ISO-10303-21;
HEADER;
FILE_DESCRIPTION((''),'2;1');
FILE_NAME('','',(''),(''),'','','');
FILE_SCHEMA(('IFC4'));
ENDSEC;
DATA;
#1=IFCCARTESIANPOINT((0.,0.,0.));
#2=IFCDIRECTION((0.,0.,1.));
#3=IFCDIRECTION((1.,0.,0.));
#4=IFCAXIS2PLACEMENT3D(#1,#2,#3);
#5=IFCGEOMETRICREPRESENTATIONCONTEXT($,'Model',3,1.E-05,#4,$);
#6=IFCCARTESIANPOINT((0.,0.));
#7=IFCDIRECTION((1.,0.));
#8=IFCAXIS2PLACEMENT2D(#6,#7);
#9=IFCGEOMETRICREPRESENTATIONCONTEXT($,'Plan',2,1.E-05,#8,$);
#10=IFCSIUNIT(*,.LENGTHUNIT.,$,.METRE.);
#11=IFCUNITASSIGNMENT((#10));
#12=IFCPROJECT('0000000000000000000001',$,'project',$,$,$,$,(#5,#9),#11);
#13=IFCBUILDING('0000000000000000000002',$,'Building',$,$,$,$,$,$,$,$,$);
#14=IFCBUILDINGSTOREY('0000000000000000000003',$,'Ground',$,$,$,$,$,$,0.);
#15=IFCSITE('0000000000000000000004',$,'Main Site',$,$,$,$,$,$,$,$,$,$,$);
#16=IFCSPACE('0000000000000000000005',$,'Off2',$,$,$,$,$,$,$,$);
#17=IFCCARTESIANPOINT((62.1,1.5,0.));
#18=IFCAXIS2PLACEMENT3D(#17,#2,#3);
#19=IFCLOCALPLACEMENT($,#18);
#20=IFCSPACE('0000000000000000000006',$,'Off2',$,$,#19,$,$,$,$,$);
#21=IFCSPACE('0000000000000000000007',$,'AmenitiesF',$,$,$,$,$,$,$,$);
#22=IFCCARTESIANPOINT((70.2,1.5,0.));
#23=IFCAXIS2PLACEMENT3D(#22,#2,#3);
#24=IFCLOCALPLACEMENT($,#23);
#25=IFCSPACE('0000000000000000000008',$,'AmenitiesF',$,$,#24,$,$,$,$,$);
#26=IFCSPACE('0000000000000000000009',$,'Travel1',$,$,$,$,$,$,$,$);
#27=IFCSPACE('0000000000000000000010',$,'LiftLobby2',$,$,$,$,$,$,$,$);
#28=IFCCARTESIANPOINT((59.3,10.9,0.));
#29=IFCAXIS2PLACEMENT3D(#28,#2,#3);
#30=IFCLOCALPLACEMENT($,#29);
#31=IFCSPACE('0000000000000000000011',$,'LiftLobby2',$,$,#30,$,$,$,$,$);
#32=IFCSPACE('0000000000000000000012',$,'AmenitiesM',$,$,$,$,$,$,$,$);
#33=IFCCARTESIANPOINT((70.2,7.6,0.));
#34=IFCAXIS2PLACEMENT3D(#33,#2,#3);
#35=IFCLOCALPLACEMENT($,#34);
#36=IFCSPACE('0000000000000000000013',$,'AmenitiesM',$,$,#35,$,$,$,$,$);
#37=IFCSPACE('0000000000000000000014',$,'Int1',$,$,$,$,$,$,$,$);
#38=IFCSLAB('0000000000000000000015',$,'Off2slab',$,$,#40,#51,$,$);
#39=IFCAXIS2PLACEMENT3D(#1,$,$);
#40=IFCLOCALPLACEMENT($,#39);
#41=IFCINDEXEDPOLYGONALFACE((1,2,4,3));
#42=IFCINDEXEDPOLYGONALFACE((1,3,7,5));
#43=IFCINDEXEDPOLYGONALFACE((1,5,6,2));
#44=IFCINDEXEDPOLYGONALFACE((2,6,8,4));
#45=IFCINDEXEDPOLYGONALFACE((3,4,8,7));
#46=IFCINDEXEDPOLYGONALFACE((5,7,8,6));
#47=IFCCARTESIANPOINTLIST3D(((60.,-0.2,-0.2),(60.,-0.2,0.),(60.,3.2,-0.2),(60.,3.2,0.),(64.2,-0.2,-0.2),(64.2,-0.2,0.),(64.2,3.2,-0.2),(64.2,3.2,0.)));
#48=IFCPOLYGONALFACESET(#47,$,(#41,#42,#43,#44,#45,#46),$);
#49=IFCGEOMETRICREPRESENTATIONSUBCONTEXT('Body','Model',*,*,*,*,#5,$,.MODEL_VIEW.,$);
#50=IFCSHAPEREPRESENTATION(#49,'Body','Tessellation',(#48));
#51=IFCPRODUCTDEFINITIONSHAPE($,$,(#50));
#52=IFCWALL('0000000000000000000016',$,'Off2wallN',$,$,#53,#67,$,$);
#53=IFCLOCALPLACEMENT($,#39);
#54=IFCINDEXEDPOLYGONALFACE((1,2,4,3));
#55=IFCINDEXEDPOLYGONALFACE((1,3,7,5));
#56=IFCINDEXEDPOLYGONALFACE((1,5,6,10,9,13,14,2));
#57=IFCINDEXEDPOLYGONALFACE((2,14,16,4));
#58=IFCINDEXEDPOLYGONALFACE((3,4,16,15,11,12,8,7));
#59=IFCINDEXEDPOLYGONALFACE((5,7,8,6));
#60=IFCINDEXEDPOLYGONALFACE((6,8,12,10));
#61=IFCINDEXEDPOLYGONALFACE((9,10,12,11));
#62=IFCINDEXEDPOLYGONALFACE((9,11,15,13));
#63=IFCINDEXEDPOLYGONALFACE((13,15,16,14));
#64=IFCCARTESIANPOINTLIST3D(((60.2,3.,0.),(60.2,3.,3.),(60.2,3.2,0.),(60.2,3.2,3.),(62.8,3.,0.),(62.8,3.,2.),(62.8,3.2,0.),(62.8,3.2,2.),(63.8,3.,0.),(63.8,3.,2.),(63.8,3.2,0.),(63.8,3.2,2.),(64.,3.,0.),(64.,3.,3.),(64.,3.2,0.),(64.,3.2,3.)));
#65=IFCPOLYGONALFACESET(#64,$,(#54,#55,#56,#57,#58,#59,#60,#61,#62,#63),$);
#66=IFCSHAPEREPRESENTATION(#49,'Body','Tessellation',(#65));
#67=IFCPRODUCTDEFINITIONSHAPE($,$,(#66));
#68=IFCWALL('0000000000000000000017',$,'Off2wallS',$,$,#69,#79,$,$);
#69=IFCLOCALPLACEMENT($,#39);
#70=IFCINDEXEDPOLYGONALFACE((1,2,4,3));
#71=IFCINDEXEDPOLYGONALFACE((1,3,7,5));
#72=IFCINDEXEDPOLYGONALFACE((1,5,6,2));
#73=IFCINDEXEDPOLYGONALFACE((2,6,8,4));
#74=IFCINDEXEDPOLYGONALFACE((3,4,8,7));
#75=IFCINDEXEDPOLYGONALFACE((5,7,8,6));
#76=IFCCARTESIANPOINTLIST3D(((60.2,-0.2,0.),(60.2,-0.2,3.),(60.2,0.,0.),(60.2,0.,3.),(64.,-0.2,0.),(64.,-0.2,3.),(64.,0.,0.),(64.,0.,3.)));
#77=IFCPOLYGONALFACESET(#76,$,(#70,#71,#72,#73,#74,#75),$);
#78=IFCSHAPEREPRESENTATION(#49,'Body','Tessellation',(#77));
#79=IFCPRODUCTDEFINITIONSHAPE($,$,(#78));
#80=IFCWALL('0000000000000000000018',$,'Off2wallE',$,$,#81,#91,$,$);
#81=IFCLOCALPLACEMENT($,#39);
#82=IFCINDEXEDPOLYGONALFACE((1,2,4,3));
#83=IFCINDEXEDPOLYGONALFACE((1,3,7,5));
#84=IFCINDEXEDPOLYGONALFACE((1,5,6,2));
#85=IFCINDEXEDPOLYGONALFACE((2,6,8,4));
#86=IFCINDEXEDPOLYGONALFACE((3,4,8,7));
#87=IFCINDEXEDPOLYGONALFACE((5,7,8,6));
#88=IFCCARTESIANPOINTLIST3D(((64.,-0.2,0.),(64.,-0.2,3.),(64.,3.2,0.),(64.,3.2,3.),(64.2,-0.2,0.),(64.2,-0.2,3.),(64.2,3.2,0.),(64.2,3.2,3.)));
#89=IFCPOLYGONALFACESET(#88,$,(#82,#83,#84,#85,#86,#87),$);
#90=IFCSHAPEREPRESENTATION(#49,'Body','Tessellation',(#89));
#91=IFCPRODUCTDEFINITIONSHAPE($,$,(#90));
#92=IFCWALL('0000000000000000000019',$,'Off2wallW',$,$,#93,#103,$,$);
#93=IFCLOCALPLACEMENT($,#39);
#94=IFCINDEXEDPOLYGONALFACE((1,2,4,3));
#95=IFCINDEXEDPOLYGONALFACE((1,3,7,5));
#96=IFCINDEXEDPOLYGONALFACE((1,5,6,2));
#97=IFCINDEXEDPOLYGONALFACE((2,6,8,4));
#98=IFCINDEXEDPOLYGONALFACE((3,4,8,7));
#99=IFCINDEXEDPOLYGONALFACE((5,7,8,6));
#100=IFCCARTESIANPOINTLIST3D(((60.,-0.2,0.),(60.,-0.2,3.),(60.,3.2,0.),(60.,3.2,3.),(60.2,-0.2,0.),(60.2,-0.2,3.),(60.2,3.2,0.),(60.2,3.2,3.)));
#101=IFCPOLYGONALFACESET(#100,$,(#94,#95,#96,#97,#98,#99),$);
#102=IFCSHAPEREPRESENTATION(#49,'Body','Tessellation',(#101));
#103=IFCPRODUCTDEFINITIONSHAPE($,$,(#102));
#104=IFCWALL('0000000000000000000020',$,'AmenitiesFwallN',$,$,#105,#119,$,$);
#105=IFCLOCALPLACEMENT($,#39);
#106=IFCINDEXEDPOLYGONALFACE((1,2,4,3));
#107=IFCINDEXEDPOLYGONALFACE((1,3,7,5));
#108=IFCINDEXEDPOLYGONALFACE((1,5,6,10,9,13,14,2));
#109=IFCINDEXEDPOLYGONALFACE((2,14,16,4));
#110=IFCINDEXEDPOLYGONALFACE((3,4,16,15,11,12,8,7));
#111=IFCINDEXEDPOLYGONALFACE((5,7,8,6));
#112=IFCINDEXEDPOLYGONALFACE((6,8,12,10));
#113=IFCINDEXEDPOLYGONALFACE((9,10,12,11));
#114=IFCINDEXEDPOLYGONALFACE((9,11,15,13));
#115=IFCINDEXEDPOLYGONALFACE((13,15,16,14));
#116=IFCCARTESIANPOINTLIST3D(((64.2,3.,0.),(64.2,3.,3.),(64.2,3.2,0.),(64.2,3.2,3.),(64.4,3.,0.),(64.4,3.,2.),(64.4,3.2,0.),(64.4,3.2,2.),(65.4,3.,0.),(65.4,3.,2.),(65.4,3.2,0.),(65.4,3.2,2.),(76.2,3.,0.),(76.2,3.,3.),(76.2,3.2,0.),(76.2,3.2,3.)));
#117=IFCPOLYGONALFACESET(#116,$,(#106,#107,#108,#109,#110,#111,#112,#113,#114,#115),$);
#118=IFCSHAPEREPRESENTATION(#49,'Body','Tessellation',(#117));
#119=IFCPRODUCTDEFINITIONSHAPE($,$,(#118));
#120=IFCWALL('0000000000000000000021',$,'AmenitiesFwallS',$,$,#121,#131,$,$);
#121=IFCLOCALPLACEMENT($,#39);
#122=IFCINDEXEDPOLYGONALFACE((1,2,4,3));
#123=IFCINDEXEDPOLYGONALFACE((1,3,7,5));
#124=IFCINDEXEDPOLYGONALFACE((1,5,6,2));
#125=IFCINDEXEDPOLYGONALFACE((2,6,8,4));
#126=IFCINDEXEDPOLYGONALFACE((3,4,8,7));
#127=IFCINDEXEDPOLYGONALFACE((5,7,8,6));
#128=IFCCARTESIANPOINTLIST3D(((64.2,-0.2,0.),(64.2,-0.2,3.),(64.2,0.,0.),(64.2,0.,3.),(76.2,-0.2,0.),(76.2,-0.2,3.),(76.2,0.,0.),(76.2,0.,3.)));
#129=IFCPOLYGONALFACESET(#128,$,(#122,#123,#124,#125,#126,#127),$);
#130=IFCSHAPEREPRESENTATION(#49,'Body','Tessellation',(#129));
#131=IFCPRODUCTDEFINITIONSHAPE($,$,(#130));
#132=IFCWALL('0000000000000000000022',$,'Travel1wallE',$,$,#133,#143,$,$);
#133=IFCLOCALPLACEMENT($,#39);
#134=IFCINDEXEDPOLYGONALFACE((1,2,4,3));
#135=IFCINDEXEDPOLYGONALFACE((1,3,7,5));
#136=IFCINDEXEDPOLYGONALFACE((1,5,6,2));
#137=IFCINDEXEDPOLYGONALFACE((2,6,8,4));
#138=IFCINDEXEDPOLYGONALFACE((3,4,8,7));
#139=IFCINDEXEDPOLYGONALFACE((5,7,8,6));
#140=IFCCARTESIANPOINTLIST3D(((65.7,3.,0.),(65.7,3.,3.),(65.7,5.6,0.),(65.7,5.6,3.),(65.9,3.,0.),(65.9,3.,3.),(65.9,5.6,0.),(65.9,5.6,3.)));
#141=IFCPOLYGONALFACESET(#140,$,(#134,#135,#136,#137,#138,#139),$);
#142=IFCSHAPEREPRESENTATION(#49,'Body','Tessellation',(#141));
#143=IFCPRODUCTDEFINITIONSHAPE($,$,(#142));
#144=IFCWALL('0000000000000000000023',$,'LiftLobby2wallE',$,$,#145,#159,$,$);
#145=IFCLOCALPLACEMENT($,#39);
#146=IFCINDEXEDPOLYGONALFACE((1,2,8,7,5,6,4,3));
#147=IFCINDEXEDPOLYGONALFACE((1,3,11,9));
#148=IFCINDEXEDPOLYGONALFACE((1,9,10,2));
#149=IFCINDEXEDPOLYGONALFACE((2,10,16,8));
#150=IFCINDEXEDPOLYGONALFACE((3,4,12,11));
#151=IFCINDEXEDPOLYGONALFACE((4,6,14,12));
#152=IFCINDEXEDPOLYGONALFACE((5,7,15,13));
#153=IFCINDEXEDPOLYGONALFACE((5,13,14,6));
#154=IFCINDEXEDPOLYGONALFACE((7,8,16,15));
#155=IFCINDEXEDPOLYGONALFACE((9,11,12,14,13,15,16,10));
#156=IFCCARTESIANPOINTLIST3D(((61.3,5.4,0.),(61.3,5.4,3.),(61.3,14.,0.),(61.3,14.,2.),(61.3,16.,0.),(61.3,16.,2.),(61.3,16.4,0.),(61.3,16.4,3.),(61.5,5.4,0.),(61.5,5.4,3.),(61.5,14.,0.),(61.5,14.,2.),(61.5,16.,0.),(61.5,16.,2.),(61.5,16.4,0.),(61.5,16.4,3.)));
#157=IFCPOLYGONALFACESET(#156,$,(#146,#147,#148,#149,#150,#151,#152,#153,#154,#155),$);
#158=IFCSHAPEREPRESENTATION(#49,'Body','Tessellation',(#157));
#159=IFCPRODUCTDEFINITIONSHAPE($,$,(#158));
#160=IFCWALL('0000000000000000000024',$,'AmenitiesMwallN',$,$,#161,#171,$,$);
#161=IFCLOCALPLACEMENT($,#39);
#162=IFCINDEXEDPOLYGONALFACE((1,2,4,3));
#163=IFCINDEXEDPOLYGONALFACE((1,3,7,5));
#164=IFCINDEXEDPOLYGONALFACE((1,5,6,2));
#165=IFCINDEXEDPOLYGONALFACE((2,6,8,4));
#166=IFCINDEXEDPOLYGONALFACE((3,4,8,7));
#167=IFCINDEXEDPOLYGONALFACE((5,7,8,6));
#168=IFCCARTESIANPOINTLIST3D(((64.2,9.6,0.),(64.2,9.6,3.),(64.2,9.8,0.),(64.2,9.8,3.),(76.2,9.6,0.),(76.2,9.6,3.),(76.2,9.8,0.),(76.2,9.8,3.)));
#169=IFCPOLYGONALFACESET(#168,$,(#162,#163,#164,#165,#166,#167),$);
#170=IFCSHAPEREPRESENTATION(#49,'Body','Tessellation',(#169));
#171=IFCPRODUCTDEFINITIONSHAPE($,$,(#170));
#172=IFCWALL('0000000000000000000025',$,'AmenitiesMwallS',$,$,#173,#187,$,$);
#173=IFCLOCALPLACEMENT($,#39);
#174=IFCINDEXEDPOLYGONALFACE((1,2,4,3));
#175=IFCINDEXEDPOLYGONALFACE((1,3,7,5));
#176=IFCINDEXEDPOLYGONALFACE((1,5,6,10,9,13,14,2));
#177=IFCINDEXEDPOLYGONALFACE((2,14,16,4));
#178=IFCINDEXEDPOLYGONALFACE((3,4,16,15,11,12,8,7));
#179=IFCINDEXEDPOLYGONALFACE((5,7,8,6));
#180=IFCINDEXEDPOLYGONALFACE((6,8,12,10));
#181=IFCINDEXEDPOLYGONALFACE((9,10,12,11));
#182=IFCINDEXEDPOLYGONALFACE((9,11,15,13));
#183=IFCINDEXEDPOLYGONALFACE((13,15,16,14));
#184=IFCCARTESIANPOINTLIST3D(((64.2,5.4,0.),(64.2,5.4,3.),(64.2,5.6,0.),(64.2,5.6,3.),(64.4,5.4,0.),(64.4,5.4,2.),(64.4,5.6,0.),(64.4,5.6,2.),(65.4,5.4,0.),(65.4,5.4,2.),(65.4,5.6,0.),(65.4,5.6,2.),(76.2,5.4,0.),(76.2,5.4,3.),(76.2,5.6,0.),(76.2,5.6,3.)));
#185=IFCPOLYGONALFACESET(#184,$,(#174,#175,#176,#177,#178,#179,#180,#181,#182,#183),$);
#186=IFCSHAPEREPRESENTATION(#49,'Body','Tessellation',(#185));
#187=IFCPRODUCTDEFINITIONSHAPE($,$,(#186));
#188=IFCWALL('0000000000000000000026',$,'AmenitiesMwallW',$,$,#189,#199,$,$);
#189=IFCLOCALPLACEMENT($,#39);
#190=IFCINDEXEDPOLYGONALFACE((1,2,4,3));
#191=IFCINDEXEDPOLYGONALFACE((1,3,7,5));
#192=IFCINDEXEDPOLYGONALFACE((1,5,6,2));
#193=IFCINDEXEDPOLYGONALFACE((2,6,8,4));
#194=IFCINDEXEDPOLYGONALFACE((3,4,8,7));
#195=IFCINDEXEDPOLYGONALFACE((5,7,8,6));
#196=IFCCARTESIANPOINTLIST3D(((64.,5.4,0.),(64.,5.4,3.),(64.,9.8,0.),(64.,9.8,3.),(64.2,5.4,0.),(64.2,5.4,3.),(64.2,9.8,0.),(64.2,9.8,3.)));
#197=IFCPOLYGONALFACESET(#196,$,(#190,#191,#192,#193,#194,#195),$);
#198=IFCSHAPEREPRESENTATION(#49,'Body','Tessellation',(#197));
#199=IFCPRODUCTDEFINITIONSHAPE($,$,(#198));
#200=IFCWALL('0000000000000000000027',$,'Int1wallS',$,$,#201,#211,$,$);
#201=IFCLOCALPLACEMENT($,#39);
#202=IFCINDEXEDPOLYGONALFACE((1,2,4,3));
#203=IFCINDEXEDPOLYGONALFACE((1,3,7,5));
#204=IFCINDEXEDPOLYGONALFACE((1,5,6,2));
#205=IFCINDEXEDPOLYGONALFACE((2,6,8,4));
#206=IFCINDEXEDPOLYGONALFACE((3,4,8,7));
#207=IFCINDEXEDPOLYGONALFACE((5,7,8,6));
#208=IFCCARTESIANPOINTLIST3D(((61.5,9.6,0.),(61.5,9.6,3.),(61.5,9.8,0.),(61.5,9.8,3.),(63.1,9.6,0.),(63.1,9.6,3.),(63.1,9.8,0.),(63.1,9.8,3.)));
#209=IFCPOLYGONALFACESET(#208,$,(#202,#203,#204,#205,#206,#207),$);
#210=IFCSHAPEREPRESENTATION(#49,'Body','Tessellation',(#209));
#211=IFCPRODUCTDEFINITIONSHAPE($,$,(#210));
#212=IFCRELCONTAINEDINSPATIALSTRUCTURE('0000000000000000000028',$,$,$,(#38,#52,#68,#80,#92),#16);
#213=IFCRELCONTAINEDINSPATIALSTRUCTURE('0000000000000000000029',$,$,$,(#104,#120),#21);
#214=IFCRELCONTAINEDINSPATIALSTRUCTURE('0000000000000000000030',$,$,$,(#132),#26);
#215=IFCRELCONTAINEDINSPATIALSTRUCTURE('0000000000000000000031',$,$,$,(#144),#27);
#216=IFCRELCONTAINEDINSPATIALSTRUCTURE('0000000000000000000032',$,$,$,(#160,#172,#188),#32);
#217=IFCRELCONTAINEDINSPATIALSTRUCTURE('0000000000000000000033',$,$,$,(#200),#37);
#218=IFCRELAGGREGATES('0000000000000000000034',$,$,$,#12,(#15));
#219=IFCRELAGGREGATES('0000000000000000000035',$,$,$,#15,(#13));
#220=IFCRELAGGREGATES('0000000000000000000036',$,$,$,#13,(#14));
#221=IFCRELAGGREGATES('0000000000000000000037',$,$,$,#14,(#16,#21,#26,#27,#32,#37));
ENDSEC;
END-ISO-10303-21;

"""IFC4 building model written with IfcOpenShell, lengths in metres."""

from ifc_helpers import new_model, si_unit, frame, origin_with_axes, origin_2d_with_axis, place, context, subcontext, project, spatial, indexed_curve, rectangle, outline, extrude, element, save


model = new_model("IFC4")

# Units and contexts
model_context = context("Model", 3, precision=1e-05, world=origin_with_axes())
plan_context = context("Plan", 2, precision=1e-05, world=origin_2d_with_axis())
body_context = subcontext(model_context, "Body", "Model", "MODEL_VIEW")
ifc_project = project(units=[si_unit("LENGTHUNIT", "METRE")], contexts=[model_context, plan_context])

# Site, building, storey, space
site = spatial("IfcSite", under=ifc_project, Name="Main Site")
building = spatial("IfcBuilding", under=site, Name="Building")
storey = spatial("IfcBuildingStorey", under=building, Name="Ground", Elevation=0.0)
space_1 = spatial("IfcSpace", under=storey, Name="Off2")

# Slab
slab_placement = place(None, frame((62.1, 1.5, -0.2), z_axis=(0.0, 0.0, 1.0), x_axis=(1.0, 0.0, 0.0)))
element("IfcSlab", 1, at=slab_placement, inside=space_1, Name="Off2slab", context=body_context, shape_type="SweptSolid", body=[
    extrude(rectangle(XDim=4.2, YDim=3.4), origin_with_axes(), (0.0, 0.0, 1.0), 0.2),
])

# Wall
wall_1_placement = place(None, frame((60.2, 3.0, 0.0), z_axis=(0.0, 0.0, 1.0), x_axis=(1.0, 0.0, 0.0)))
wall_1 = element("IfcWall", 2, at=wall_1_placement, inside=space_1, Name="Off2wallN", context=body_context, shape_type="SweptSolid", body=[
    extrude(outline(indexed_curve([(0.0, 0.0), (0.0, 0.2), (3.8, 0.2), (3.8, 0.0), (0.0, 0.0)], self_intersect=False)), origin_with_axes(), (0.0, 0.0, 1.0), 3.0),
])

# Shared definitions
space_2_placement = place(None, frame((62.1, 1.5, 0.0), z_axis=(0.0, 0.0, 1.0), x_axis=(1.0, 0.0, 0.0)))
space_2 = spatial("IfcSpace", at=space_2_placement, Name="Off2")

# Opening
opening_1_placement = place(wall_1_placement, frame((2.6, 0.0, 0.0), z_axis=(0.0, 0.0, 1.0), x_axis=(1.0, 0.0, 0.0)))
element("IfcOpeningElement", 3, at=opening_1_placement, inside=space_2, cuts=wall_1, context=body_context, shape_type="SweptSolid", body=[
    extrude(outline(indexed_curve([(0.0, 0.0), (0.0, 0.4), (1.0, 0.4), (1.0, 0.0), (0.0, 0.0)], self_intersect=False)), origin_with_axes(), (0.0, 0.0, 1.0), 2.0),
])

# Walls
wall_2_placement = place(None, frame((60.2, -0.2, 0.0), z_axis=(0.0, 0.0, 1.0), x_axis=(1.0, 0.0, 0.0)))
element("IfcWall", 4, at=wall_2_placement, inside=space_1, Name="Off2wallS", context=body_context, shape_type="SweptSolid", body=[
    extrude(outline(indexed_curve([(0.0, 0.0), (0.0, 0.2), (3.8, 0.2), (3.8, 0.0), (0.0, 0.0)], self_intersect=False)), origin_with_axes(), (0.0, 0.0, 1.0), 3.0),
])
for number, where, z_axis, x_axis, name in (
    (5, (64.2, -0.2, 0.0), (0.0, 0.0, 1.0), (0.0, 1.0, 0.0), "Off2wallE"),
    (6, (60.2, -0.2, 0.0), (0.0, 0.0, 1.0), (0.0, 1.0, 0.0), "Off2wallW"),
):
    element("IfcWall", number, at=place(None, frame(where, z_axis=z_axis, x_axis=x_axis)), inside=space_1, Name=name, context=body_context, shape_type="SweptSolid", body=[
        extrude(outline(indexed_curve([(0.0, 0.0), (0.0, 0.2), (3.4, 0.2), (3.4, 0.0), (0.0, 0.0)], self_intersect=False)), origin_with_axes(), (0.0, 0.0, 1.0), 3.0),
    ])

# Shared definitions
space_3 = spatial("IfcSpace", under=storey, Name="AmenitiesF")

# Wall
wall_3_placement = place(None, frame((64.2, 3.0, 0.0), z_axis=(0.0, 0.0, 1.0), x_axis=(1.0, 0.0, 0.0)))
wall_3 = element("IfcWall", 7, at=wall_3_placement, inside=space_3, Name="AmenitiesFwallN", context=body_context, shape_type="SweptSolid", body=[
    extrude(outline(indexed_curve([(0.0, 0.0), (0.0, 0.2), (12.0, 0.2), (12.0, 0.0), (0.0, 0.0)], self_intersect=False)), origin_with_axes(), (0.0, 0.0, 1.0), 3.0),
])

# Shared definitions
space_4_placement = place(None, frame((70.2, 1.5, 0.0), z_axis=(0.0, 0.0, 1.0), x_axis=(1.0, 0.0, 0.0)))
space_4 = spatial("IfcSpace", at=space_4_placement, Name="AmenitiesF")

# Opening
opening_2_placement = place(wall_3_placement, frame((0.2, 0.0, 0.0), z_axis=(0.0, 0.0, 1.0), x_axis=(1.0, 0.0, 0.0)))
element("IfcOpeningElement", 8, at=opening_2_placement, inside=space_4, cuts=wall_3, context=body_context, shape_type="SweptSolid", body=[
    extrude(outline(indexed_curve([(0.0, 0.0), (0.0, 0.4), (1.0, 0.4), (1.0, 0.0), (0.0, 0.0)], self_intersect=False)), origin_with_axes(), (0.0, 0.0, 1.0), 2.0),
])

# Wall
wall_4_placement = place(None, frame((64.2, -0.2, 0.0), z_axis=(0.0, 0.0, 1.0), x_axis=(1.0, 0.0, 0.0)))
element("IfcWall", 9, at=wall_4_placement, inside=space_3, Name="AmenitiesFwallS", context=body_context, shape_type="SweptSolid", body=[
    extrude(outline(indexed_curve([(0.0, 0.0), (0.0, 0.2), (12.0, 0.2), (12.0, 0.0), (0.0, 0.0)], self_intersect=False)), origin_with_axes(), (0.0, 0.0, 1.0), 3.0),
])

# Shared definitions
space_5 = spatial("IfcSpace", under=storey, Name="Travel1")

# Wall
wall_5_placement = place(None, frame((65.9, 3.0, 0.0), z_axis=(0.0, 0.0, 1.0), x_axis=(0.0, 1.0, 0.0)))
element("IfcWall", 10, at=wall_5_placement, inside=space_5, Name="Travel1wallE", context=body_context, shape_type="SweptSolid", body=[
    extrude(outline(indexed_curve([(0.0, 0.0), (0.0, 0.2), (2.6, 0.2), (2.6, 0.0), (0.0, 0.0)], self_intersect=False)), origin_with_axes(), (0.0, 0.0, 1.0), 3.0),
])

# Shared definitions
space_6 = spatial("IfcSpace", under=storey, Name="LiftLobby2")

# Wall
wall_6_placement = place(None, frame((61.5, 5.4, 0.0), z_axis=(0.0, 0.0, 1.0), x_axis=(0.0, 1.0, 0.0)))
wall_6 = element("IfcWall", 11, at=wall_6_placement, inside=space_6, Name="LiftLobby2wallE", context=body_context, shape_type="SweptSolid", body=[
    extrude(outline(indexed_curve([(0.0, 0.0), (0.0, 0.2), (11.0, 0.2), (11.0, 0.0), (0.0, 0.0)], self_intersect=False)), origin_with_axes(), (0.0, 0.0, 1.0), 3.0),
])

# Shared definitions
space_7_placement = place(None, frame((59.3, 10.9, 0.0), z_axis=(0.0, 0.0, 1.0), x_axis=(1.0, 0.0, 0.0)))
space_7 = spatial("IfcSpace", at=space_7_placement, Name="LiftLobby2")

# Opening
opening_3_placement = place(wall_6_placement, frame((8.6, 0.0, 0.0), z_axis=(0.0, 0.0, 1.0), x_axis=(1.0, 0.0, 0.0)))
element("IfcOpeningElement", 12, at=opening_3_placement, inside=space_7, cuts=wall_6, context=body_context, shape_type="SweptSolid", body=[
    extrude(outline(indexed_curve([(0.0, 0.0), (0.0, 0.4), (2.0, 0.4), (2.0, 0.0), (0.0, 0.0)], self_intersect=False)), origin_with_axes(), (0.0, 0.0, 1.0), 2.0),
])

# Shared definitions
space_8 = spatial("IfcSpace", under=storey, Name="AmenitiesM")

# Walls
wall_7_placement = place(None, frame((64.2, 9.6, 0.0), z_axis=(0.0, 0.0, 1.0), x_axis=(1.0, 0.0, 0.0)))
element("IfcWall", 13, at=wall_7_placement, inside=space_8, Name="AmenitiesMwallN", context=body_context, shape_type="SweptSolid", body=[
    extrude(outline(indexed_curve([(0.0, 0.0), (0.0, 0.2), (12.0, 0.2), (12.0, 0.0), (0.0, 0.0)], self_intersect=False)), origin_with_axes(), (0.0, 0.0, 1.0), 3.0),
])
wall_8_placement = place(None, frame((64.2, 5.4, 0.0), z_axis=(0.0, 0.0, 1.0), x_axis=(1.0, 0.0, 0.0)))
wall_8 = element("IfcWall", 14, at=wall_8_placement, inside=space_8, Name="AmenitiesMwallS", context=body_context, shape_type="SweptSolid", body=[
    extrude(outline(indexed_curve([(0.0, 0.0), (0.0, 0.2), (12.0, 0.2), (12.0, 0.0), (0.0, 0.0)], self_intersect=False)), origin_with_axes(), (0.0, 0.0, 1.0), 3.0),
])

# Shared definitions
space_9_placement = place(None, frame((70.2, 7.6, 0.0), z_axis=(0.0, 0.0, 1.0), x_axis=(1.0, 0.0, 0.0)))
space_9 = spatial("IfcSpace", at=space_9_placement, Name="AmenitiesM")

# Opening
opening_4_placement = place(wall_8_placement, frame((0.2, 0.0, 0.0), z_axis=(0.0, 0.0, 1.0), x_axis=(1.0, 0.0, 0.0)))
element("IfcOpeningElement", 15, at=opening_4_placement, inside=space_9, cuts=wall_8, context=body_context, shape_type="SweptSolid", body=[
    extrude(outline(indexed_curve([(0.0, 0.0), (0.0, 0.4), (1.0, 0.4), (1.0, 0.0), (0.0, 0.0)], self_intersect=False)), origin_with_axes(), (0.0, 0.0, 1.0), 2.0),
])

# Wall
wall_9_placement = place(None, frame((64.2, 5.4, 0.0), z_axis=(0.0, 0.0, 1.0), x_axis=(0.0, 1.0, 0.0)))
element("IfcWall", 16, at=wall_9_placement, inside=space_8, Name="AmenitiesMwallW", context=body_context, shape_type="SweptSolid", body=[
    extrude(outline(indexed_curve([(0.0, 0.0), (0.0, 0.2), (4.4, 0.2), (4.4, 0.0), (0.0, 0.0)], self_intersect=False)), origin_with_axes(), (0.0, 0.0, 1.0), 3.0),
])

# Shared definitions
space_10 = spatial("IfcSpace", under=storey, Name="Int1")

# Wall
wall_10_placement = place(None, frame((61.5, 9.6, 0.0), z_axis=(0.0, 0.0, 1.0), x_axis=(1.0, 0.0, 0.0)))
element("IfcWall", 17, at=wall_10_placement, inside=space_10, Name="Int1wallS", context=body_context, shape_type="SweptSolid", body=[
    extrude(outline(indexed_curve([(0.0, 0.0), (0.0, 0.2), (1.6, 0.2), (1.6, 0.0), (0.0, 0.0)], self_intersect=False)), origin_with_axes(), (0.0, 0.0, 1.0), 3.0),
])

save(model, "model.ifc")
